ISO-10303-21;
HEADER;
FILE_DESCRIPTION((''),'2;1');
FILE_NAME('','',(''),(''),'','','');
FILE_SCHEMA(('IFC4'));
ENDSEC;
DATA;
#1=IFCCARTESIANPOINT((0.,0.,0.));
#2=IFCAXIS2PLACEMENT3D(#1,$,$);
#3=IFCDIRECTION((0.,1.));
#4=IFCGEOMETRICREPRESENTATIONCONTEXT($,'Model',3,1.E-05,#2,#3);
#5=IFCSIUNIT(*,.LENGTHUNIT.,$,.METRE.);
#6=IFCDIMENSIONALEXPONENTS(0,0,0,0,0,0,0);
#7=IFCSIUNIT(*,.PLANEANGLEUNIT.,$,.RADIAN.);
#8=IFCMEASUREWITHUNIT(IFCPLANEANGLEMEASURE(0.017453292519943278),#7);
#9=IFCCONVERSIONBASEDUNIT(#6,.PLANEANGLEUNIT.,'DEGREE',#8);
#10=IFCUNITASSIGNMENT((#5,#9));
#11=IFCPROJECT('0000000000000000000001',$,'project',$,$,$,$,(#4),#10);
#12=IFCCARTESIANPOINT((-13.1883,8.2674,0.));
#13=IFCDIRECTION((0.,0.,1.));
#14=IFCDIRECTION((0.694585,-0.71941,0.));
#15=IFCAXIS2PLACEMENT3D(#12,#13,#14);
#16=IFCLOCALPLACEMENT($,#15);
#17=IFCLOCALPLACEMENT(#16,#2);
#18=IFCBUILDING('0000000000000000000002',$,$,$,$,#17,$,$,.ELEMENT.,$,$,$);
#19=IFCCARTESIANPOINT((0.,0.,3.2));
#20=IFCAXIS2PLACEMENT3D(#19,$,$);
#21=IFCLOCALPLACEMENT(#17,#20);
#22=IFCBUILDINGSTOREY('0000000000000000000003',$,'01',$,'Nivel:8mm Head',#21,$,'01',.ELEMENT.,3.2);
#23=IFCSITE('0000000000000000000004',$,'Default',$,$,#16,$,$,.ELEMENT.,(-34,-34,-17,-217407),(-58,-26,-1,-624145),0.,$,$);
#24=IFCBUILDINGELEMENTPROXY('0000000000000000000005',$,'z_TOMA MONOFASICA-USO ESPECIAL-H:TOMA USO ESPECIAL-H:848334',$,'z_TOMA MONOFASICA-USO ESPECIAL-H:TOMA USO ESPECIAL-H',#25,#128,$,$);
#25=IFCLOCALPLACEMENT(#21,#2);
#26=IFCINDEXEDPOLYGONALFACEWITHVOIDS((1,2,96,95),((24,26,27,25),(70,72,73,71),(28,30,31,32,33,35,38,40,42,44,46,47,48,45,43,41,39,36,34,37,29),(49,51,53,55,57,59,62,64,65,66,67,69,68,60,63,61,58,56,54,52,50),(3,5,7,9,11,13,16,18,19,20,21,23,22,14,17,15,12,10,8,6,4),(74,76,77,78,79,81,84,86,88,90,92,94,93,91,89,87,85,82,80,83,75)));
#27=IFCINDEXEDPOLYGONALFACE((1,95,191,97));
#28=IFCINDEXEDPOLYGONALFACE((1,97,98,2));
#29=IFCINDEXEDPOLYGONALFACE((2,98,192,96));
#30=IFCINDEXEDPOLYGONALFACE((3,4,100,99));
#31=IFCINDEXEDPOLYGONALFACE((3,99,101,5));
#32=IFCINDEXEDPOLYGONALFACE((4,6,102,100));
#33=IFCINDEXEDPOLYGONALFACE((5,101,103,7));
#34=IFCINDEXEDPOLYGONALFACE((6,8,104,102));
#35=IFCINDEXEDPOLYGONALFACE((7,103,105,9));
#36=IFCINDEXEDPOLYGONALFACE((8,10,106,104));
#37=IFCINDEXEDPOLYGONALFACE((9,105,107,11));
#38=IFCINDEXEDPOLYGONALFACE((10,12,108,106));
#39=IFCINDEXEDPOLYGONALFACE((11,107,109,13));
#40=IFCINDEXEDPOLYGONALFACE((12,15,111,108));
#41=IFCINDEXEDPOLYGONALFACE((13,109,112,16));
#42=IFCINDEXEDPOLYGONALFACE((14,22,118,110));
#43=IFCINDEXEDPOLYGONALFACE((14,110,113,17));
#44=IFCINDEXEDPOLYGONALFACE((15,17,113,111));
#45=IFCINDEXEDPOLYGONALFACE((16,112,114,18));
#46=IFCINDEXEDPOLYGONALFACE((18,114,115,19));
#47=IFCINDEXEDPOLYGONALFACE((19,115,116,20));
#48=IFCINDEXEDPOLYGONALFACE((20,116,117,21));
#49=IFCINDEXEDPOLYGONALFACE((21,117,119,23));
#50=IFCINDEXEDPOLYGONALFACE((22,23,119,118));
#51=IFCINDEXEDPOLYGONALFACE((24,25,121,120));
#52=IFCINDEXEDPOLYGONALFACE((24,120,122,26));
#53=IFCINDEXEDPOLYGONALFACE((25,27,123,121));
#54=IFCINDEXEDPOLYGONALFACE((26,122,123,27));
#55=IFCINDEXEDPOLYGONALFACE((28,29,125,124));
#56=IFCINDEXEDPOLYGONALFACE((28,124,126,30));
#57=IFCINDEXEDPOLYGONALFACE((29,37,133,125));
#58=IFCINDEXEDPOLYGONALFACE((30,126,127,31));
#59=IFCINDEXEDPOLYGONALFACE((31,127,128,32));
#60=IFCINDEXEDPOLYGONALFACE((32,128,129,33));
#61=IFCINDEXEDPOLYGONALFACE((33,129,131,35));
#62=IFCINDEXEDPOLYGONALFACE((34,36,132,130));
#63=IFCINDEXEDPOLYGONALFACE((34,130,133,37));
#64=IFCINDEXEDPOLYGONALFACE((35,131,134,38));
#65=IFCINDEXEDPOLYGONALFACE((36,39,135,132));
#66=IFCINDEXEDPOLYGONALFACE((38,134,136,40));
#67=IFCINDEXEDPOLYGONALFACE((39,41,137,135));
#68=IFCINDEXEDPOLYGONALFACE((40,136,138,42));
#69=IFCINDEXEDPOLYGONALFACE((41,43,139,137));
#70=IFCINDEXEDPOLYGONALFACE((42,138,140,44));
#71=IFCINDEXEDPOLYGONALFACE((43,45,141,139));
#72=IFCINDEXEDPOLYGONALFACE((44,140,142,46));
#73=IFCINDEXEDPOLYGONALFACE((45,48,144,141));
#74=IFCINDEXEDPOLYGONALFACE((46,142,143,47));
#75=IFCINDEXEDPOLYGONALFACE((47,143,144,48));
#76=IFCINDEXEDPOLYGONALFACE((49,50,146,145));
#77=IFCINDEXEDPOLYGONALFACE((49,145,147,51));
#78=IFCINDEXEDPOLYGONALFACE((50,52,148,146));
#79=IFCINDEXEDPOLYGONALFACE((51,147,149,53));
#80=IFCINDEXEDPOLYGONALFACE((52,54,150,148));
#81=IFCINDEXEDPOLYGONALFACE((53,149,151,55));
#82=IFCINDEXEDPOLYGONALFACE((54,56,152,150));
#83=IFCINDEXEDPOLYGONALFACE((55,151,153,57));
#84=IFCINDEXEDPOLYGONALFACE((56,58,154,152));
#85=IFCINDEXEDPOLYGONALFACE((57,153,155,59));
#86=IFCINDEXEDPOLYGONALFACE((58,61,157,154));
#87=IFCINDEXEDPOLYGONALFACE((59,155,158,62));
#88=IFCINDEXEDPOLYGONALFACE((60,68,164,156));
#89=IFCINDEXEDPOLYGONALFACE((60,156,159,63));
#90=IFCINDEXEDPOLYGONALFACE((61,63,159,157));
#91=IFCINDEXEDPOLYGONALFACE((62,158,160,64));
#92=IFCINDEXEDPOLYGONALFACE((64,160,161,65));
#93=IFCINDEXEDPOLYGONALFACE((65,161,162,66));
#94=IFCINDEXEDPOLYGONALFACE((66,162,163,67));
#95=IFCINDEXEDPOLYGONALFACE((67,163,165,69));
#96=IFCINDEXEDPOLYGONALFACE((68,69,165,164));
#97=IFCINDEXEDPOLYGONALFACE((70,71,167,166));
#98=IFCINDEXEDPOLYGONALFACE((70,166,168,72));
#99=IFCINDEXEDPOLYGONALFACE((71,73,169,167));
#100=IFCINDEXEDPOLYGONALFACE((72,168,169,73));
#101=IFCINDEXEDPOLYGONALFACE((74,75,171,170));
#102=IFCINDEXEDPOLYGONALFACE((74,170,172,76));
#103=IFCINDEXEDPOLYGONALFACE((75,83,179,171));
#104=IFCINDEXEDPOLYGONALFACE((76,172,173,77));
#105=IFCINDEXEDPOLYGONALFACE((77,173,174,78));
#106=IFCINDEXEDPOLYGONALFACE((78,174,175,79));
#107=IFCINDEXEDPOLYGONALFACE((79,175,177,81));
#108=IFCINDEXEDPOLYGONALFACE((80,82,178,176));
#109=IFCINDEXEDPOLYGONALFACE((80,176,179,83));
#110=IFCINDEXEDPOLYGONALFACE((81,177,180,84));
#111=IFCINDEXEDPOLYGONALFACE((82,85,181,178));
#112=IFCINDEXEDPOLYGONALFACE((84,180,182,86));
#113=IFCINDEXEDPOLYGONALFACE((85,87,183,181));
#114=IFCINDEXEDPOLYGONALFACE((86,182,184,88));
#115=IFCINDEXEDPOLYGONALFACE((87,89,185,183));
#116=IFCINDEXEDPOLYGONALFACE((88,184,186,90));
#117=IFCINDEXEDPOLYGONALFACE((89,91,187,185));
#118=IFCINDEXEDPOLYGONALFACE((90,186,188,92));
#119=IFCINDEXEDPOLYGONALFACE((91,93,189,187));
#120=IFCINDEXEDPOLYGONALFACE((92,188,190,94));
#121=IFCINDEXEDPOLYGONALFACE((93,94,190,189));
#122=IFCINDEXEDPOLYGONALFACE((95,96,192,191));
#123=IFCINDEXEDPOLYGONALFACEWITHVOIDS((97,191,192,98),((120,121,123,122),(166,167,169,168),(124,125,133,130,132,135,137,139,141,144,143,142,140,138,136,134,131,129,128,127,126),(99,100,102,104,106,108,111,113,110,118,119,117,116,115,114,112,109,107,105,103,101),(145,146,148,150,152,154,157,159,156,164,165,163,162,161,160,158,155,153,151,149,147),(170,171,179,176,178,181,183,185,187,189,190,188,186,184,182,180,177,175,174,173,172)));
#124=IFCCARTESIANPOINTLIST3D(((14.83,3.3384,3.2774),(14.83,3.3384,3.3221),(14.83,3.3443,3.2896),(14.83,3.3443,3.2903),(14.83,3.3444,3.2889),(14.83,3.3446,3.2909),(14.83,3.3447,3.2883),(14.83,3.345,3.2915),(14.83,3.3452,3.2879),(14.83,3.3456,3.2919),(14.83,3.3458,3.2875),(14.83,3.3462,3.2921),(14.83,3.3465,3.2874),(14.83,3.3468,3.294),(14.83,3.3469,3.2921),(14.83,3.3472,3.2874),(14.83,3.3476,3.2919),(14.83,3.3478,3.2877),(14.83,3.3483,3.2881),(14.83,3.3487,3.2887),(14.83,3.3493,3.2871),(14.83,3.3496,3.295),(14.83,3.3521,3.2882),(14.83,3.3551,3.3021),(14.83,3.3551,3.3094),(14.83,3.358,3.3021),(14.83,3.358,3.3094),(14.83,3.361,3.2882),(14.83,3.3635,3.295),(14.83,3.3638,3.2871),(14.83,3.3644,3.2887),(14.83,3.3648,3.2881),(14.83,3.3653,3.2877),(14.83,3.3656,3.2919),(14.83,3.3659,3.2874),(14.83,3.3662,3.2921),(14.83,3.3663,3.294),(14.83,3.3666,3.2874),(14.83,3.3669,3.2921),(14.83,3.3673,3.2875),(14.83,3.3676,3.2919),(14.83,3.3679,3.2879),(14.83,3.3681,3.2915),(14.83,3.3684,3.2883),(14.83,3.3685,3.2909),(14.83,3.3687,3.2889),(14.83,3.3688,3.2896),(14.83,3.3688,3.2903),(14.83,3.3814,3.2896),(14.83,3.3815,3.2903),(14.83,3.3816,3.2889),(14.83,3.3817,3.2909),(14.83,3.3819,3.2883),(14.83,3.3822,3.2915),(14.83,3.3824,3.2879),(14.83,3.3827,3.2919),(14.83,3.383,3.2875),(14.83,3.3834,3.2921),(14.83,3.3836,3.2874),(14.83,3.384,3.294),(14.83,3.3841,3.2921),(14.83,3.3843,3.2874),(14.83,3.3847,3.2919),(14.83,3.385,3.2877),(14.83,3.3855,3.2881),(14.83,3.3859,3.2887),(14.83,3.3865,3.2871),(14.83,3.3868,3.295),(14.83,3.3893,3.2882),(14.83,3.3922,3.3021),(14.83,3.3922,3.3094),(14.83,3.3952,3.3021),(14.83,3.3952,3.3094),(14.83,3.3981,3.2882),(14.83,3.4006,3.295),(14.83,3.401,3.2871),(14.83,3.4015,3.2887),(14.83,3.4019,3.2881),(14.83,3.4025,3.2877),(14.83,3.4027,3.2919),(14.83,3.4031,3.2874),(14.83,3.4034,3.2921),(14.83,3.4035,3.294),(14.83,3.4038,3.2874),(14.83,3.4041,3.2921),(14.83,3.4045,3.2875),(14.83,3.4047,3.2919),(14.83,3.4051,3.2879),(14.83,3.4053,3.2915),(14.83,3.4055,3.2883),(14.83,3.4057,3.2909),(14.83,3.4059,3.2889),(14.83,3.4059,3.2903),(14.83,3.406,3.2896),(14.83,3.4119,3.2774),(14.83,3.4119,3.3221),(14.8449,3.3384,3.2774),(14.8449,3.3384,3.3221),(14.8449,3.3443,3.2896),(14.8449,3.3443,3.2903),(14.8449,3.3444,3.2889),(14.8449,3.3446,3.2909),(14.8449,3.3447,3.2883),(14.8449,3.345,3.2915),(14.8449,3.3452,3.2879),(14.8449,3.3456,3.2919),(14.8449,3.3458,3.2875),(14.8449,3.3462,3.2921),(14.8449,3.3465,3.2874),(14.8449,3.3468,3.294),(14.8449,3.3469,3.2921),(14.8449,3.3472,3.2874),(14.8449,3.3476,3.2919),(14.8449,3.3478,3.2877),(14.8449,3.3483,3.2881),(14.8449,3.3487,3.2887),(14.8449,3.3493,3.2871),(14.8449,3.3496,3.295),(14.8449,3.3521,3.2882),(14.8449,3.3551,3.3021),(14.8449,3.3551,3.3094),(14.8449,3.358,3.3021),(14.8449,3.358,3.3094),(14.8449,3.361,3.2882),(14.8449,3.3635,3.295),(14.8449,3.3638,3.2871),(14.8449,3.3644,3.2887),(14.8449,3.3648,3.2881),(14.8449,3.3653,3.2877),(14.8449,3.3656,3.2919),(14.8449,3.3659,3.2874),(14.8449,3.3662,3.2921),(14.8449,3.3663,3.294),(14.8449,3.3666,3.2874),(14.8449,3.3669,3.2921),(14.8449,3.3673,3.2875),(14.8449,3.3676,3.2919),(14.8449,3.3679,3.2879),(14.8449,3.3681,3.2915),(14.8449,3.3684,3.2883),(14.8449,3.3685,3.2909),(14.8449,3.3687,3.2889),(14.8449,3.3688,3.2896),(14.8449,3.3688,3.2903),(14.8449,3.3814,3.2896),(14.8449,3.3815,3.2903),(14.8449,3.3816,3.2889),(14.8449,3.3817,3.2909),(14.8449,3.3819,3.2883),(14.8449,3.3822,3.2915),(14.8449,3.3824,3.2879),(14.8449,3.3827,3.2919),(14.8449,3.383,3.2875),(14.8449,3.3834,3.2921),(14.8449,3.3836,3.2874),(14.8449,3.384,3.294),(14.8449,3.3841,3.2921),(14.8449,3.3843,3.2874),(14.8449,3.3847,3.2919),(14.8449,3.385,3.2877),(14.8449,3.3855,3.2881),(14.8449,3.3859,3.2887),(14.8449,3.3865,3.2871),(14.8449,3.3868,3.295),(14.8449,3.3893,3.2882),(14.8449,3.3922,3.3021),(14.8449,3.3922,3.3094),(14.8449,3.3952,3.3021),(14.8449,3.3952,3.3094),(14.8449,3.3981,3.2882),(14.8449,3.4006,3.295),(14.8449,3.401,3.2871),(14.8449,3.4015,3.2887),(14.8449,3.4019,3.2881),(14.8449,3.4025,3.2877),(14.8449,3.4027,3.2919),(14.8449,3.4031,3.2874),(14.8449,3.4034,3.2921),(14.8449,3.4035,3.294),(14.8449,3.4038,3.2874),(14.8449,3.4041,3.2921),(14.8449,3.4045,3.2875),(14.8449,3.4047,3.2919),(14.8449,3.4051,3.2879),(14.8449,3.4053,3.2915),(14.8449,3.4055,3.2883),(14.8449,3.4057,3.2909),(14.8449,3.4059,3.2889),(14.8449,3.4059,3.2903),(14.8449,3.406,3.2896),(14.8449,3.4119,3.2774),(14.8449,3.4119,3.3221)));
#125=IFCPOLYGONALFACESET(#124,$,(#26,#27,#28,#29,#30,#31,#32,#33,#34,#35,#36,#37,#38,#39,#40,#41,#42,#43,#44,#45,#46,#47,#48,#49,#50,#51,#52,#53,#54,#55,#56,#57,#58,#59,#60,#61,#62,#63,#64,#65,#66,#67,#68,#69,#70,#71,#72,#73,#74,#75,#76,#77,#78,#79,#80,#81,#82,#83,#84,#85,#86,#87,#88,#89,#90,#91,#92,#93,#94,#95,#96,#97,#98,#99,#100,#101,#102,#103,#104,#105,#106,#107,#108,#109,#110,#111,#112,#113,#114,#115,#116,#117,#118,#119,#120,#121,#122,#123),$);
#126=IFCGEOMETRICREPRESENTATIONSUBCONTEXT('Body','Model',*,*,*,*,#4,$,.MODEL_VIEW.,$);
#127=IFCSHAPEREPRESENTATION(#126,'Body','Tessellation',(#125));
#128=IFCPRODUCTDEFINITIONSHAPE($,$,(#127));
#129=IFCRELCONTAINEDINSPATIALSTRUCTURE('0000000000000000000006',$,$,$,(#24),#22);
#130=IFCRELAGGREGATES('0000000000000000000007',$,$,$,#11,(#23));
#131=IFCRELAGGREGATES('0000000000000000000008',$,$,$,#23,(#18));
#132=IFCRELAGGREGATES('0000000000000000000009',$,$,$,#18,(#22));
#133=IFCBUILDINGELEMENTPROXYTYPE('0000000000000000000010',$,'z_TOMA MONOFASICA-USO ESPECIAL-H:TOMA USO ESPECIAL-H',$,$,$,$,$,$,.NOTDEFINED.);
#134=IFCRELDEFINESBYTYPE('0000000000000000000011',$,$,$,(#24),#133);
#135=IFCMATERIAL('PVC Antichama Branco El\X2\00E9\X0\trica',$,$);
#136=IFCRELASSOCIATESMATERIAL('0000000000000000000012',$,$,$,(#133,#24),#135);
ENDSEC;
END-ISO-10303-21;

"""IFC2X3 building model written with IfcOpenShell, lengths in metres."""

from ifc_helpers import new_model, entity, si_unit, converted_unit, direction, frame, frame_2d, origin, place, context, subcontext, project, spatial, polyline, circle_curve, parameter, trimmed, segment, composite_curve, outline, extrude, source, transform, mapped, material, type_object, type_shapes, element, save


model = new_model("IFC2X3")

# Units and contexts
model_context = context("Model", 3, precision=1e-05, world=origin(), true_north=direction((0.0, 1.0)))
body_context = subcontext(model_context, "Body", "Model", "MODEL_VIEW")
ifc_project = project(units=[si_unit("LENGTHUNIT", "METRE"), converted_unit("PLANEANGLEUNIT", "DEGREE", entity("IfcPlaneAngleMeasure", 0.017453292519943278), si_unit("PLANEANGLEUNIT", "RADIAN"), dimensions=[0, 0, 0, 0, 0, 0, 0])], contexts=[model_context])

# Site, building, storey
site_placement = place(None, frame((-13.1883, 8.2674, 0.0), z_axis=(0.0, 0.0, 1.0), x_axis=(0.694585, -0.71941, 0.0)))
site = spatial("IfcSite", under=ifc_project, at=site_placement, Name="Default", CompositionType="ELEMENT", RefLatitude=(-34, -34, -17, -217407), RefLongitude=(-58, -26, -1, -624145), RefElevation=0.0)
building_placement = place(site_placement, origin())
building = spatial("IfcBuilding", under=site, at=building_placement, CompositionType="ELEMENT")
storey_placement = place(building_placement, frame((0.0, 0.0, 3.2)))
storey = spatial("IfcBuildingStorey", under=building, at=storey_placement, Name="01", ObjectType="Nivel:8mm Head", LongName="01", CompositionType="ELEMENT", Elevation=3.2)

# Building element proxy
ifc_material_1 = material(Name="PVC Antichama Branco Elétrica")
building_element_proxy_type_1 = type_object("IfcBuildingElementProxyType", Name="z_TOMA MONOFASICA-USO ESPECIAL-H:TOMA USO ESPECIAL-H", PredefinedType="NOTDEFINED", material=ifc_material_1)
shared_shape_1 = source(origin(), body_context, "Body", "SweptSolid", [
    extrude(outline(polyline([(-0.0368, -0.0223), (0.0368, -0.0223), (0.0368, 0.0223), (-0.0368, 0.0223), (-0.0368, -0.0223)]), holes=[composite_curve([segment(polyline([(0.0141, 0.0115), (0.0116, 0.0047)]), True, "CONTINUOUS"), segment(polyline([(0.0116, 0.0047), (0.0088, 0.0057)]), True, "CONTINUOUS"), segment(polyline([(0.0088, 0.0057), (0.0096, 0.0078)]), True, "CONTINUOUS"), segment(trimmed(circle_curve(frame_2d((0.0087, 0.0099), x_axis=(1.0, 0.0)), 0.0024), [parameter(27.118901)], [parameter(292.881099)], True, "PARAMETER"), False, "CONTINUOUS"), segment(polyline([(0.0108, 0.011), (0.0113, 0.0126)]), True, "CONTINUOUS"), segment(polyline([(0.0113, 0.0126), (0.0141, 0.0115)]), True, "CONTINUOUS")], self_intersect=False), composite_curve([segment(polyline([(0.0255, 0.0047), (0.023, 0.0115)]), True, "CONTINUOUS"), segment(polyline([(0.023, 0.0115), (0.0258, 0.0126)]), True, "CONTINUOUS"), segment(polyline([(0.0258, 0.0126), (0.0264, 0.011)]), True, "CONTINUOUS"), segment(trimmed(circle_curve(frame_2d((0.0285, 0.0099), x_axis=(1.0, 0.0)), 0.0024), [parameter(247.118901)], [parameter(152.881099)], True, "PARAMETER"), False, "CONTINUOUS"), segment(polyline([(0.0276, 0.0078), (0.0283, 0.0057)]), True, "CONTINUOUS"), segment(polyline([(0.0283, 0.0057), (0.0255, 0.0047)]), True, "CONTINUOUS")], self_intersect=False), polyline([(0.0201, -0.0024), (0.0201, -0.0097), (0.0171, -0.0097), (0.0171, -0.0024), (0.0201, -0.0024)]), composite_curve([segment(polyline([(-0.0141, 0.0115), (-0.0113, 0.0126)]), True, "CONTINUOUS"), segment(polyline([(-0.0113, 0.0126), (-0.0108, 0.011)]), True, "CONTINUOUS"), segment(trimmed(circle_curve(frame_2d((-0.0087, 0.0099), x_axis=(1.0, 0.0)), 0.0024), [parameter(247.118901)], [parameter(152.881099)], True, "PARAMETER"), False, "CONTINUOUS"), segment(polyline([(-0.0096, 0.0078), (-0.0088, 0.0057)]), True, "CONTINUOUS"), segment(polyline([(-0.0088, 0.0057), (-0.0116, 0.0047)]), True, "CONTINUOUS"), segment(polyline([(-0.0116, 0.0047), (-0.0141, 0.0115)]), True, "CONTINUOUS")], self_intersect=False), composite_curve([segment(polyline([(-0.0255, 0.0047), (-0.0283, 0.0057)]), True, "CONTINUOUS"), segment(polyline([(-0.0283, 0.0057), (-0.0276, 0.0078)]), True, "CONTINUOUS"), segment(trimmed(circle_curve(frame_2d((-0.0285, 0.0099), x_axis=(1.0, 0.0)), 0.0024), [parameter(27.118901)], [parameter(292.881099)], True, "PARAMETER"), False, "CONTINUOUS"), segment(polyline([(-0.0264, 0.011), (-0.0258, 0.0126)]), True, "CONTINUOUS"), segment(polyline([(-0.0258, 0.0126), (-0.023, 0.0115)]), True, "CONTINUOUS"), segment(polyline([(-0.023, 0.0115), (-0.0255, 0.0047)]), True, "CONTINUOUS")], self_intersect=False), polyline([(-0.0201, -0.0024), (-0.0171, -0.0024), (-0.0171, -0.0097), (-0.0201, -0.0097), (-0.0201, -0.0024)])]), frame((0.0, -0.005, 0.0223), z_axis=(0.0, 1.0, 0.0), x_axis=(1.0, 0.0, 0.0)), (0.0, 0.0, 1.0), 0.0148),
])
type_shapes(building_element_proxy_type_1, [shared_shape_1])
proxy_1_placement = place(storey_placement, frame((14.8399, 3.3751, 3.2774), z_axis=(0.0, 0.0, 1.0), x_axis=(0.0, 1.0, 0.0)))
element("IfcBuildingElementProxy", 1, at=proxy_1_placement, inside=storey, type_object=building_element_proxy_type_1, material=ifc_material_1, Name="z_TOMA MONOFASICA-USO ESPECIAL-H:TOMA USO ESPECIAL-H:848334", ObjectType="z_TOMA MONOFASICA-USO ESPECIAL-H:TOMA USO ESPECIAL-H", context=body_context, shape_type="MappedRepresentation", body=[
    mapped(shared_shape_1, transform((0.0, 0.0, 0.0), scale=1.0)),
])

save(model, "model.ifc")
